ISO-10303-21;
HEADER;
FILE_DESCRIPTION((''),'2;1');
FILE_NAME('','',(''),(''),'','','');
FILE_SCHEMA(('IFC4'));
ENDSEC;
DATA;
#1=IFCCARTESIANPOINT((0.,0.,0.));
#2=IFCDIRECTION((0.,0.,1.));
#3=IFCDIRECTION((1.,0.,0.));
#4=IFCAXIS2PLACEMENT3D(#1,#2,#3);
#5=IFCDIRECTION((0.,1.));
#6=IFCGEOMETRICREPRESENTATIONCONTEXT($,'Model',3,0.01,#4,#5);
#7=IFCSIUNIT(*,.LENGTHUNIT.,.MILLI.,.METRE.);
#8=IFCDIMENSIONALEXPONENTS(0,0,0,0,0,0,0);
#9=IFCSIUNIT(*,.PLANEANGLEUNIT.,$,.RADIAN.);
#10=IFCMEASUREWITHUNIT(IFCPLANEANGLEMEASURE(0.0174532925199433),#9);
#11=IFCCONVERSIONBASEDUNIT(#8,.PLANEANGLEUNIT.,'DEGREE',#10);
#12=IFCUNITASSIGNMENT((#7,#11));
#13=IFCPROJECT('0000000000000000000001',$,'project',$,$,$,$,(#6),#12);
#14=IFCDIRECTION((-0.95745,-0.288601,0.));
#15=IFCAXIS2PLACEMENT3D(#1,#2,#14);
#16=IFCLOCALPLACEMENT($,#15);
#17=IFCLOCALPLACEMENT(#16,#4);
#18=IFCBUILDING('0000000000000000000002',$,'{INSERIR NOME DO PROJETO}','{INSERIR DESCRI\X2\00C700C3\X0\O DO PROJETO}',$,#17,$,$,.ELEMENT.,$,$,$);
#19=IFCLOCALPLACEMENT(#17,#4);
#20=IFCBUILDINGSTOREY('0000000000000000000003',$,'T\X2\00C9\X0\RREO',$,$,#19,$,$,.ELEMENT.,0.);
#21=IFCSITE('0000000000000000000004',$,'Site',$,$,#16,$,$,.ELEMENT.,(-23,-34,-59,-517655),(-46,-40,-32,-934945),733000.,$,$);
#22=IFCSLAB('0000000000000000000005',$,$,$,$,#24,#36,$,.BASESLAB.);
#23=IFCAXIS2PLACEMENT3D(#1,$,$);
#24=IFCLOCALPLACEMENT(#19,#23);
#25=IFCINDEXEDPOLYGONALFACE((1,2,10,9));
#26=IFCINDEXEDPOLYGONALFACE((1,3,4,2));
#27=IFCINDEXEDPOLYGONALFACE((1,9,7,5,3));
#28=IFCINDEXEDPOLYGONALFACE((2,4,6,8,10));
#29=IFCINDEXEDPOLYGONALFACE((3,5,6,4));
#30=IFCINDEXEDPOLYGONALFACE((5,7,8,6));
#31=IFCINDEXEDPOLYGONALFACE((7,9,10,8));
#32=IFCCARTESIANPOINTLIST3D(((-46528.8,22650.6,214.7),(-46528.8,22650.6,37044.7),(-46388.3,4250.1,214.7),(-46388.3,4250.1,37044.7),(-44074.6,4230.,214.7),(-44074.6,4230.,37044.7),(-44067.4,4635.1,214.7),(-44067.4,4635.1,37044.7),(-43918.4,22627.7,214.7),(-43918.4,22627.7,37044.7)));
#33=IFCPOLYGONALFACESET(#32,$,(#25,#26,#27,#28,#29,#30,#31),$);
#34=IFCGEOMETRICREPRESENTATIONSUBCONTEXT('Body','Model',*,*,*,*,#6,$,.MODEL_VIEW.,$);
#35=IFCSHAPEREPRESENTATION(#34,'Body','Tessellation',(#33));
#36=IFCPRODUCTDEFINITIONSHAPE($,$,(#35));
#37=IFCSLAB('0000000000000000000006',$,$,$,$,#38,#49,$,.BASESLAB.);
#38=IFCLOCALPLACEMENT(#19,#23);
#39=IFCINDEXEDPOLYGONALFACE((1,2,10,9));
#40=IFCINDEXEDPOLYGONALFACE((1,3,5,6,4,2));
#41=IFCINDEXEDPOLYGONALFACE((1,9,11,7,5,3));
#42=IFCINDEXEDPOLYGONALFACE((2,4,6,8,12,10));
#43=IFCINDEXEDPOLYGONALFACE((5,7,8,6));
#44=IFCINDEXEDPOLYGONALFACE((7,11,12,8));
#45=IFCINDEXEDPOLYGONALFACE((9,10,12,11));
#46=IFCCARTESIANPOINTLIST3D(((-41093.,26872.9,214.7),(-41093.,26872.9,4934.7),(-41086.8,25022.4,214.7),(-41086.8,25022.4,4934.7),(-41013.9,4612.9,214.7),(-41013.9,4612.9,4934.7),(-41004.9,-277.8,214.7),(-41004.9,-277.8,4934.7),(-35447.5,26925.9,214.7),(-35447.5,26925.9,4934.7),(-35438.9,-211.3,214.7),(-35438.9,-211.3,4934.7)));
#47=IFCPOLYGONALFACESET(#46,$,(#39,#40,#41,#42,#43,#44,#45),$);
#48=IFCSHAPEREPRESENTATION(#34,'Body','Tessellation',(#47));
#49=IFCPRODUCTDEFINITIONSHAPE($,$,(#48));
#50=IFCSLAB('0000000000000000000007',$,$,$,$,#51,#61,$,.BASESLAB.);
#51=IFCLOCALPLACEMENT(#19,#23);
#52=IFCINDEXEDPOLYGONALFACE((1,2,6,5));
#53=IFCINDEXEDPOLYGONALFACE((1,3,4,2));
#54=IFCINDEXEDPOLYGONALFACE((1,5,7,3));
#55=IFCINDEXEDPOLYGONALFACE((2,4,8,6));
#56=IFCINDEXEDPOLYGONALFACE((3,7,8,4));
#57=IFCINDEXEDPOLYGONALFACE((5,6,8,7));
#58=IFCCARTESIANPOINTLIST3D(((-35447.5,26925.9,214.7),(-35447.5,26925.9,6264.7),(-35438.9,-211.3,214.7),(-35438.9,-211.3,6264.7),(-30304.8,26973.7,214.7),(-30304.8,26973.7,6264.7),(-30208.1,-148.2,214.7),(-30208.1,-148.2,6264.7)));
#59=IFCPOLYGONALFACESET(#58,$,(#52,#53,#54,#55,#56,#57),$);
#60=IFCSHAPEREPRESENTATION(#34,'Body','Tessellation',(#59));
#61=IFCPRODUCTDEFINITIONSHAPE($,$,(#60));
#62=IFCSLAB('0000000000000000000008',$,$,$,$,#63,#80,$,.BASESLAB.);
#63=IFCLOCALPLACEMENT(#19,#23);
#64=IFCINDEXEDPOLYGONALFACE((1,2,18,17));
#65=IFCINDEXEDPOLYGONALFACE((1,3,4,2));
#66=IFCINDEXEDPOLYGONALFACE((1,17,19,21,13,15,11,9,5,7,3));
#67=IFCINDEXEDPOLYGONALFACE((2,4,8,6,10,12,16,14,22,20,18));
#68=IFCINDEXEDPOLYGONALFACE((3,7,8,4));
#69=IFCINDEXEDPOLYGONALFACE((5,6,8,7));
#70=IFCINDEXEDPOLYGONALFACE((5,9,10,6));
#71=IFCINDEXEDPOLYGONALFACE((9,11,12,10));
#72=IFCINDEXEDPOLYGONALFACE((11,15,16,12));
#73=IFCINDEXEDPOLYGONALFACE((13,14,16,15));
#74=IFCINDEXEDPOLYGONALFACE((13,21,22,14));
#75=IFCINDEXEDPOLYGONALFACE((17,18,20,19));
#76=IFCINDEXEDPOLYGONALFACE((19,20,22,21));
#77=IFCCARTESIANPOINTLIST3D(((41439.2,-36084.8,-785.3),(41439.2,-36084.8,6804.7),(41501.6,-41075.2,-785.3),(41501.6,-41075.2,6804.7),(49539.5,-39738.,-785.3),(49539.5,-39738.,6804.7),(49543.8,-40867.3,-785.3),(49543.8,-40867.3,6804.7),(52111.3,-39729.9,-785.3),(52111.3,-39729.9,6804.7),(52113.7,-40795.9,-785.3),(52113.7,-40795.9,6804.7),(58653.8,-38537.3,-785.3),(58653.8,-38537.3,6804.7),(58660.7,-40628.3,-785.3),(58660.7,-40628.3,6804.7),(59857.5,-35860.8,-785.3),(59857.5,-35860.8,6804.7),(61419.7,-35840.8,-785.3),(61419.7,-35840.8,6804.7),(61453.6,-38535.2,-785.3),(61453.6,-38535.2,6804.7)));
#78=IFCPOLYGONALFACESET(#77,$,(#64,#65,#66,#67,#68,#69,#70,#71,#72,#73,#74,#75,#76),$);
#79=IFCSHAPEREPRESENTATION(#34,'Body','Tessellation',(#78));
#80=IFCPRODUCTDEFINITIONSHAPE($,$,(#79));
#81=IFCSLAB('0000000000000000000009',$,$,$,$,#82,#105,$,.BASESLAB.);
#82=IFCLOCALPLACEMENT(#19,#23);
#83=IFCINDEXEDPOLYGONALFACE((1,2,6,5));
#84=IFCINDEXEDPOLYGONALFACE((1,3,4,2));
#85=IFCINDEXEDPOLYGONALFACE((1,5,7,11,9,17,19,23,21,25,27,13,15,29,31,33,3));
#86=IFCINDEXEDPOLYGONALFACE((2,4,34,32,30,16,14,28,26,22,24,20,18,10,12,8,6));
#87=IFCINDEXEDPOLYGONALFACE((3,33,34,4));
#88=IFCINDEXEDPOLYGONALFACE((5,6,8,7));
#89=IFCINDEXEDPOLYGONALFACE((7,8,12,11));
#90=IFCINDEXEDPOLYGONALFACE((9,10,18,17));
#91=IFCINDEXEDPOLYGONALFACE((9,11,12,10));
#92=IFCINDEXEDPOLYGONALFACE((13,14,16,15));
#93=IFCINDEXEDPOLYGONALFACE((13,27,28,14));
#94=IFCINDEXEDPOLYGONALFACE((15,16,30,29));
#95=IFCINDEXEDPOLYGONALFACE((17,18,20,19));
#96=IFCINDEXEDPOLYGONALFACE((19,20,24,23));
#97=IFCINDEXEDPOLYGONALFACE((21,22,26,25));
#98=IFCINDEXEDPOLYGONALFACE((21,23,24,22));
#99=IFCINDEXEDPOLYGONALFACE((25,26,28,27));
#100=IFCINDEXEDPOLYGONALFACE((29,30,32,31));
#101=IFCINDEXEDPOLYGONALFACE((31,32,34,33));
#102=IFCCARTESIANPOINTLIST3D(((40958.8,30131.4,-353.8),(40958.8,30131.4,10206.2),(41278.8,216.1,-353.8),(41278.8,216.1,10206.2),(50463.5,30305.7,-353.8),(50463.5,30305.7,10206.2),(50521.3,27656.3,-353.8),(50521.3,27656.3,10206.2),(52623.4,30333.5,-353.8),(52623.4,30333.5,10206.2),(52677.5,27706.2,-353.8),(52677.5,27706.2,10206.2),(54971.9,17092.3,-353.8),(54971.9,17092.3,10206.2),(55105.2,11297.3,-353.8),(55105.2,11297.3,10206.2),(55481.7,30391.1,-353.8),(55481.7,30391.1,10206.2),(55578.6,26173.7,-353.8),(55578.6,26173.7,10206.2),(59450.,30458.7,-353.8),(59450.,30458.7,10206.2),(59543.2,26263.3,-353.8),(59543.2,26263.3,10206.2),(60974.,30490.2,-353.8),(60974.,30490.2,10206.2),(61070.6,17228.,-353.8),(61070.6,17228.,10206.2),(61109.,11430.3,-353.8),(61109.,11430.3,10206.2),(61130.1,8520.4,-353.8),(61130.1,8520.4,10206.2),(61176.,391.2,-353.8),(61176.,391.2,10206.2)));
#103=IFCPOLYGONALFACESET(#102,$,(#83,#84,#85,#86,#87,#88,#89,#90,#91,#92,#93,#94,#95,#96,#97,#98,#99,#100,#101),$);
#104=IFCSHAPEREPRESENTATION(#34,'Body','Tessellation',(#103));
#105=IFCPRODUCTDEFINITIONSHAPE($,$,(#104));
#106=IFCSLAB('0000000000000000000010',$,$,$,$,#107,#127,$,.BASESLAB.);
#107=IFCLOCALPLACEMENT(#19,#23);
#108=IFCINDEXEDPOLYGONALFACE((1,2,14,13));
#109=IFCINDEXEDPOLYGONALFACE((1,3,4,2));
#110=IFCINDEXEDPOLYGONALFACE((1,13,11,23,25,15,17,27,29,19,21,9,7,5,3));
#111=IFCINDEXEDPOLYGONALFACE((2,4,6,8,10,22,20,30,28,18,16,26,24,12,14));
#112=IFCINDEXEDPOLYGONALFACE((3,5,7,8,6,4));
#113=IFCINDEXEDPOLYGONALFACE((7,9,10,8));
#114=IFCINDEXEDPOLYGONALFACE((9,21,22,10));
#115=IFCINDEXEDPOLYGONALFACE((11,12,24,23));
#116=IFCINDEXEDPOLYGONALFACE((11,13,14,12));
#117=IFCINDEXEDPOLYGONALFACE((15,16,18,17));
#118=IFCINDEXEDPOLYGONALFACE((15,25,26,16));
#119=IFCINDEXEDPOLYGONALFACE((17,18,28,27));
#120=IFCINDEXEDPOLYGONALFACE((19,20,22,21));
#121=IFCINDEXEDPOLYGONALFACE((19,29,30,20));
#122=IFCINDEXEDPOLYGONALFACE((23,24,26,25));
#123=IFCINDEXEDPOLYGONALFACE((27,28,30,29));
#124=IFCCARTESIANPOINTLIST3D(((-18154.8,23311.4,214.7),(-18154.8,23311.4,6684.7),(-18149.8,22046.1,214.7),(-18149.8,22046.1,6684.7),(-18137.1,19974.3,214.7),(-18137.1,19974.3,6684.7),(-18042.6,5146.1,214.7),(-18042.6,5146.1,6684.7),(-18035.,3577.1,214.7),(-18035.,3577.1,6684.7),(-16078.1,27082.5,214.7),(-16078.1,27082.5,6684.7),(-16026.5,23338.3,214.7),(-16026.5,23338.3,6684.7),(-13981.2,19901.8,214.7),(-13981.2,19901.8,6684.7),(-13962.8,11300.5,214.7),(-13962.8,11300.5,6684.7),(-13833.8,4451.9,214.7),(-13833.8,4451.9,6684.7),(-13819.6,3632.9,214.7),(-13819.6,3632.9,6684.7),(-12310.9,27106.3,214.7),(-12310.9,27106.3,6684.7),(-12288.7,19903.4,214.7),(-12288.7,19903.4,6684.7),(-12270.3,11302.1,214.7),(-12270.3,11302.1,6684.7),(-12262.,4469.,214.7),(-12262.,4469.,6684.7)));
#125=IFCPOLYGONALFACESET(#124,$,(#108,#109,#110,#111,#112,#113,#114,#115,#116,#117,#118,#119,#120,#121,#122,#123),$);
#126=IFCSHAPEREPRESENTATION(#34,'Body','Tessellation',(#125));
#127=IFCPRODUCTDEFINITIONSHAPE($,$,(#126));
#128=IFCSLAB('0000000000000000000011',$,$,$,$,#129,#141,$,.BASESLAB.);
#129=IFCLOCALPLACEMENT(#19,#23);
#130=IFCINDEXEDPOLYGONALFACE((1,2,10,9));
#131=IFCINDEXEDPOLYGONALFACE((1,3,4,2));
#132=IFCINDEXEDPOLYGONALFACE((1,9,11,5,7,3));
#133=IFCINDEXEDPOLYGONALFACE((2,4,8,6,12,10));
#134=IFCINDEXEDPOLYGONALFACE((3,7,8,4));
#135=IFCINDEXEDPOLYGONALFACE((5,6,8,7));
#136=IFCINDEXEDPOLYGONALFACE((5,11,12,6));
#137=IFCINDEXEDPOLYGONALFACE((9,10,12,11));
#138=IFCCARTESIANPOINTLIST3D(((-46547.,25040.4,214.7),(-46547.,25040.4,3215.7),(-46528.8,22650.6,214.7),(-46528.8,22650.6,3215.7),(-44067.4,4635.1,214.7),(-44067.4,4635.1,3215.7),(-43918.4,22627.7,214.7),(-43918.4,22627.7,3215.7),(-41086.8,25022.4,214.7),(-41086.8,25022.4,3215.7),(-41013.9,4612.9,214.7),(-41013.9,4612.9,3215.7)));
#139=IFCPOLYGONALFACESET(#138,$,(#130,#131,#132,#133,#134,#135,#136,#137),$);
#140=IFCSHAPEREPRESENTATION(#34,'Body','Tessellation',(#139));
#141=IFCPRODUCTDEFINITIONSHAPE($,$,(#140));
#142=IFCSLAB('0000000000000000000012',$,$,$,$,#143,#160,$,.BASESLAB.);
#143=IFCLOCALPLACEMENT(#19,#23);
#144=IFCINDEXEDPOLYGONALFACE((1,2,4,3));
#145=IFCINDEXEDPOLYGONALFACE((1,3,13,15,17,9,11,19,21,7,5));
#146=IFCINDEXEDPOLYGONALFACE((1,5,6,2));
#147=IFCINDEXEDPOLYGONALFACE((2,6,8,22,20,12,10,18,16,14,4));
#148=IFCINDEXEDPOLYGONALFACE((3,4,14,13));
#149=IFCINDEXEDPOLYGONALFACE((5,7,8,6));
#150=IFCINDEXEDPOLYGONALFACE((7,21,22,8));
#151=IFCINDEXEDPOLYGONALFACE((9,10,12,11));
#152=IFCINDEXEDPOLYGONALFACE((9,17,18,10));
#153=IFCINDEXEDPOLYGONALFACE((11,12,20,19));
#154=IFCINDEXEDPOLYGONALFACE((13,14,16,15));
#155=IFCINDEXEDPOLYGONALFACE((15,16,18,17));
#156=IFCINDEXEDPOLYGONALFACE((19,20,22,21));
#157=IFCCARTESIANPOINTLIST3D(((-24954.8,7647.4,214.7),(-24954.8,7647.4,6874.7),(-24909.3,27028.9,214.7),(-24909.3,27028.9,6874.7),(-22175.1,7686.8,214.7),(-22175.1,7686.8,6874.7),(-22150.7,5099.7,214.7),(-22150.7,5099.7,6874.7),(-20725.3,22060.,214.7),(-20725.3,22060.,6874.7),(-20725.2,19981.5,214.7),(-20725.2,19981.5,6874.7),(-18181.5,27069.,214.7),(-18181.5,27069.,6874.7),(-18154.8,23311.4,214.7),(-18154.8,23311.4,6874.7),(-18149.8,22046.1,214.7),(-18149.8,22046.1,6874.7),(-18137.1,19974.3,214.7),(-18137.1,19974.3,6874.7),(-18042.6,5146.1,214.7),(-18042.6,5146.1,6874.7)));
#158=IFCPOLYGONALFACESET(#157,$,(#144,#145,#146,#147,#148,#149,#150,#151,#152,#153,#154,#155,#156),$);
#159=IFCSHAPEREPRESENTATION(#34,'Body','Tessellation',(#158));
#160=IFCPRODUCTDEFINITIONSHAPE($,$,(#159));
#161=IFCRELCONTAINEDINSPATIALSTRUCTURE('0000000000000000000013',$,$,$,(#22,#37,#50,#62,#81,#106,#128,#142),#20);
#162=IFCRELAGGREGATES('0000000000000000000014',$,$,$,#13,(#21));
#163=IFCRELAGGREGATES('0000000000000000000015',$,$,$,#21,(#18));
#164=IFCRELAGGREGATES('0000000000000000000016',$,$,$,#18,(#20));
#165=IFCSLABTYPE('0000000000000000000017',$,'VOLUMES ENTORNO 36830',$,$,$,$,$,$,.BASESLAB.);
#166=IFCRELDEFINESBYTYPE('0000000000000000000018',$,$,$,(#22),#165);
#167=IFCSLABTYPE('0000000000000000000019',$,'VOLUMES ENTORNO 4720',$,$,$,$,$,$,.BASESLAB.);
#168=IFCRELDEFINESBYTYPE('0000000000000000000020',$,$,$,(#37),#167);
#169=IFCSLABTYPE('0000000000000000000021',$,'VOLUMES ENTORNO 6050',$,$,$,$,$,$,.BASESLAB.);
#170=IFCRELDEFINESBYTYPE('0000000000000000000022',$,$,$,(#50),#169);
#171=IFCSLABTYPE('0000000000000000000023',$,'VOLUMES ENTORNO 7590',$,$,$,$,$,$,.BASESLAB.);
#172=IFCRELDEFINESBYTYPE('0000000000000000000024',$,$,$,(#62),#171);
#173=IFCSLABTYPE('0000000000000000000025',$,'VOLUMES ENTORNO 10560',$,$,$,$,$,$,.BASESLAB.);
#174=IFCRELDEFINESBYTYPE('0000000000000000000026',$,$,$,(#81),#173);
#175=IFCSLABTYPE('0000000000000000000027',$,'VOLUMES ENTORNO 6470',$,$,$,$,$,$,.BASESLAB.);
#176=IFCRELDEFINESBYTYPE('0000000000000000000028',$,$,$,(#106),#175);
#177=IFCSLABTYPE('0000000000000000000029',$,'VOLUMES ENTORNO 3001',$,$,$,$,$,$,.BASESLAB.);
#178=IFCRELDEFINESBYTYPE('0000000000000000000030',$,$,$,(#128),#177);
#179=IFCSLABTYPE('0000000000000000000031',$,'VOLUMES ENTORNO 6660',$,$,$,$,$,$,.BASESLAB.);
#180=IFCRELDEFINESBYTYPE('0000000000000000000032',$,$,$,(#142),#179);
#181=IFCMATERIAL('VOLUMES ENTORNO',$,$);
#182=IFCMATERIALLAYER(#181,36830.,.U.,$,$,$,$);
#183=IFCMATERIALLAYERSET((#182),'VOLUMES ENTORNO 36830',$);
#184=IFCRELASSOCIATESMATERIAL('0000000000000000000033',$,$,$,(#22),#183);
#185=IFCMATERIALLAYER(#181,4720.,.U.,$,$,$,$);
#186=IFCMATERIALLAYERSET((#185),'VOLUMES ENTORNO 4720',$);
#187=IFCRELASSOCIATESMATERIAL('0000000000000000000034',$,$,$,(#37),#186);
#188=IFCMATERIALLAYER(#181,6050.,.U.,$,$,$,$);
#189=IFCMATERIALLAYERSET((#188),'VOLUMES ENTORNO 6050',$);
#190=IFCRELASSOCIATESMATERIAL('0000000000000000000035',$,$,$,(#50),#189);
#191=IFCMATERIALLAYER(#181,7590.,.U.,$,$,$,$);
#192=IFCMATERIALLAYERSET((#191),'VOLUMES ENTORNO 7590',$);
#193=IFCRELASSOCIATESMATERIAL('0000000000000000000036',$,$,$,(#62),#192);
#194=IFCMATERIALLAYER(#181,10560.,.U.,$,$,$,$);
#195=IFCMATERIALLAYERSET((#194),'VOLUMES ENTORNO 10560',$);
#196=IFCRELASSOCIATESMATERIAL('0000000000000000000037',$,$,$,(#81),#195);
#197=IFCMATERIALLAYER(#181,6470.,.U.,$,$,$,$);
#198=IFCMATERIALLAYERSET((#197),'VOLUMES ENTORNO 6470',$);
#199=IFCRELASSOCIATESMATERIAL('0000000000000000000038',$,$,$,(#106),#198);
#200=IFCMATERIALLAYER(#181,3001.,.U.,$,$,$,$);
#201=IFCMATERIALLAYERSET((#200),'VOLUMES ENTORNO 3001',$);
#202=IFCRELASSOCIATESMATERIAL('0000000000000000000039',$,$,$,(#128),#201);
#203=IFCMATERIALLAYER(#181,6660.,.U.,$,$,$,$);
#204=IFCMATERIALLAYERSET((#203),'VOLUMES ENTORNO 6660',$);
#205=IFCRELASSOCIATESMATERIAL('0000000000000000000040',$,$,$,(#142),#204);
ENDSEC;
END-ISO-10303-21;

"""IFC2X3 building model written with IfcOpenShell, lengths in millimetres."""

from ifc_helpers import new_model, entity, si_unit, converted_unit, direction, frame, origin_with_axes, place, context, subcontext, project, spatial, polyline, outline, extrude, material, layer, layer_set, layer_usage, type_object, element, save


model = new_model("IFC2X3")

# Units and contexts
model_context = context("Model", 3, precision=0.01, world=origin_with_axes(), true_north=direction((0.0, 1.0)))
body_context = subcontext(model_context, "Body", "Model", "MODEL_VIEW")
ifc_project = project(units=[si_unit("LENGTHUNIT", "METRE", prefix="MILLI"), converted_unit("PLANEANGLEUNIT", "DEGREE", entity("IfcPlaneAngleMeasure", 0.0174532925199433), si_unit("PLANEANGLEUNIT", "RADIAN"), dimensions=[0, 0, 0, 0, 0, 0, 0])], contexts=[model_context])

# Site, building, storey
site_placement = place(None, frame((0.0, 0.0, 0.0), z_axis=(0.0, 0.0, 1.0), x_axis=(-0.95745, -0.288601, 0.0)))
site = spatial("IfcSite", under=ifc_project, at=site_placement, Name="Site", CompositionType="ELEMENT", RefLatitude=(-23, -34, -59, -517655), RefLongitude=(-46, -40, -32, -934945), RefElevation=733000.0)
building_placement = place(site_placement, origin_with_axes())
building = spatial("IfcBuilding", under=site, at=building_placement, Name="{INSERIR NOME DO PROJETO}", Description="{INSERIR DESCRIÇÃO DO PROJETO}", CompositionType="ELEMENT")
storey_placement = place(building_placement, origin_with_axes())
storey = spatial("IfcBuildingStorey", under=building, at=storey_placement, Name="TÉRREO", CompositionType="ELEMENT", Elevation=0.0)

# Slabs
ifc_material_1 = material(Name="VOLUMES ENTORNO")
ifc_layer_1 = layer(ifc_material_1, 36830.0, ventilated="UNKNOWN")
ifc_layer_set_1 = layer_set([ifc_layer_1], Name="VOLUMES ENTORNO 36830")
ifc_layer_usage_1 = layer_usage(ifc_layer_set_1, "AXIS3", "NEGATIVE", 36830.0)
slab_type_1 = type_object("IfcSlabType", Name="VOLUMES ENTORNO 36830", PredefinedType="BASESLAB")
slab_1_placement = place(storey_placement, frame((-43918.4, 22627.7, 214.7), z_axis=(0.0, 0.0, 1.0), x_axis=(1.0, 0.0, 0.0)))
element("IfcSlab", 1, at=slab_1_placement, inside=storey, type_object=slab_type_1, material=ifc_layer_usage_1, PredefinedType="BASESLAB", context=body_context, shape_type="SweptSolid", body=[
    extrude(outline(polyline([(0.0, 0.0), (-2610.4, 22.9), (-2469.9, -18377.6), (-156.2, -18397.7), (-149.0, -17992.6), (0.0, 0.0)])), origin_with_axes(), (0.0, 0.0, 1.0), 36830.0),
])
ifc_layer_2 = layer(ifc_material_1, 4720.0, ventilated="UNKNOWN")
ifc_layer_set_2 = layer_set([ifc_layer_2], Name="VOLUMES ENTORNO 4720")
ifc_layer_usage_2 = layer_usage(ifc_layer_set_2, "AXIS3", "NEGATIVE", 4720.0)
slab_type_2 = type_object("IfcSlabType", Name="VOLUMES ENTORNO 4720", PredefinedType="BASESLAB")
slab_2_placement = place(storey_placement, frame((-41093.0, 26872.9, 214.7), z_axis=(0.0, 0.0, 1.0), x_axis=(1.0, 0.0, 0.0)))
element("IfcSlab", 2, at=slab_2_placement, inside=storey, type_object=slab_type_2, material=ifc_layer_usage_2, PredefinedType="BASESLAB", context=body_context, shape_type="SweptSolid", body=[
    extrude(outline(polyline([(0.0, 0.0), (6.2, -1850.5), (79.1, -22260.0), (88.0, -27150.7), (5654.1, -27084.2), (5645.5, 53.0), (0.0, 0.0)])), origin_with_axes(), (0.0, 0.0, 1.0), 4720.0),
])
ifc_layer_3 = layer(ifc_material_1, 6050.0, ventilated="UNKNOWN")
ifc_layer_set_3 = layer_set([ifc_layer_3], Name="VOLUMES ENTORNO 6050")
ifc_layer_usage_3 = layer_usage(ifc_layer_set_3, "AXIS3", "NEGATIVE", 6050.0)
slab_type_3 = type_object("IfcSlabType", Name="VOLUMES ENTORNO 6050", PredefinedType="BASESLAB")
slab_3_placement = place(storey_placement, frame((-35447.5, 26925.9, 214.7), z_axis=(0.0, 0.0, 1.0), x_axis=(1.0, 0.0, 0.0)))
element("IfcSlab", 3, at=slab_3_placement, inside=storey, type_object=slab_type_3, material=ifc_layer_usage_3, PredefinedType="BASESLAB", context=body_context, shape_type="SweptSolid", body=[
    extrude(outline(polyline([(0.0, 0.0), (8.6, -27137.2), (5239.3, -27074.1), (5142.6, 47.9), (0.0, 0.0)])), origin_with_axes(), (0.0, 0.0, 1.0), 6050.0),
])
ifc_layer_4 = layer(ifc_material_1, 7590.0, ventilated="UNKNOWN")
ifc_layer_set_4 = layer_set([ifc_layer_4], Name="VOLUMES ENTORNO 7590")
ifc_layer_usage_4 = layer_usage(ifc_layer_set_4, "AXIS3", "NEGATIVE", 7590.0)
slab_type_4 = type_object("IfcSlabType", Name="VOLUMES ENTORNO 7590", PredefinedType="BASESLAB")
slab_4_placement = place(storey_placement, frame((41501.6, -41075.2, -785.3), z_axis=(0.0, 0.0, 1.0), x_axis=(1.0, 0.0, 0.0)))
element("IfcSlab", 4, at=slab_4_placement, inside=storey, type_object=slab_type_4, material=ifc_layer_usage_4, PredefinedType="BASESLAB", context=body_context, shape_type="SweptSolid", body=[
    extrude(outline(polyline([(0.0, 0.0), (8042.2, 207.9), (8037.9, 1337.1), (10609.7, 1345.3), (10612.1, 279.2), (17159.1, 446.9), (17152.3, 2537.8), (19952.0, 2539.9), (19918.2, 5234.3), (18355.9, 5214.3), (-62.4, 4990.4), (0.0, 0.0)])), origin_with_axes(), (0.0, 0.0, 1.0), 7590.0),
])
ifc_layer_5 = layer(ifc_material_1, 10560.0, ventilated="UNKNOWN")
ifc_layer_set_5 = layer_set([ifc_layer_5], Name="VOLUMES ENTORNO 10560")
ifc_layer_usage_5 = layer_usage(ifc_layer_set_5, "AXIS3", "NEGATIVE", 10560.0)
slab_type_5 = type_object("IfcSlabType", Name="VOLUMES ENTORNO 10560", PredefinedType="BASESLAB")
slab_5_placement = place(storey_placement, frame((61176.0, 391.2, -353.8), z_axis=(0.0, 0.0, 1.0), x_axis=(1.0, 0.0, 0.0)))
element("IfcSlab", 5, at=slab_5_placement, inside=storey, type_object=slab_type_5, material=ifc_layer_usage_5, PredefinedType="BASESLAB", context=body_context, shape_type="SweptSolid", body=[
    extrude(outline(polyline([(0.0, 0.0), (-45.9, 8129.1), (-67.0, 11039.0), (-6070.8, 10906.1), (-6204.0, 16701.1), (-105.4, 16836.8), (-202.0, 30099.0), (-1725.9, 30067.5), (-1632.8, 25872.1), (-5597.3, 25782.5), (-5694.3, 29999.9), (-8552.5, 29942.3), (-8498.5, 27314.9), (-10654.6, 27265.1), (-10712.5, 29914.5), (-20217.2, 29740.2), (-19897.2, -175.1), (0.0, 0.0)])), origin_with_axes(), (0.0, 0.0, 1.0), 10560.0),
])
ifc_layer_6 = layer(ifc_material_1, 6470.0, ventilated="UNKNOWN")
ifc_layer_set_6 = layer_set([ifc_layer_6], Name="VOLUMES ENTORNO 6470")
ifc_layer_usage_6 = layer_usage(ifc_layer_set_6, "AXIS3", "NEGATIVE", 6470.0)
slab_type_6 = type_object("IfcSlabType", Name="VOLUMES ENTORNO 6470", PredefinedType="BASESLAB")
slab_6_placement = place(storey_placement, frame((-13819.6, 3632.9, 214.7), z_axis=(0.0, 0.0, 1.0), x_axis=(1.0, 0.0, 0.0)))
element("IfcSlab", 6, at=slab_6_placement, inside=storey, type_object=slab_type_6, material=ifc_layer_usage_6, PredefinedType="BASESLAB", context=body_context, shape_type="SweptSolid", body=[
    extrude(outline(polyline([(0.0, 0.0), (-14.3, 819.0), (1557.6, 836.1), (1549.3, 7669.2), (-143.2, 7667.6), (-161.7, 16268.9), (1530.8, 16270.5), (1508.6, 23473.4), (-2258.5, 23449.6), (-2206.9, 19705.4), (-4335.2, 19678.5), (-4330.2, 18413.2), (-4317.6, 16341.4), (-4223.0, 1513.1), (-4215.5, -55.8), (0.0, 0.0)])), origin_with_axes(), (0.0, 0.0, 1.0), 6470.0),
])
ifc_layer_7 = layer(ifc_material_1, 3001.0, ventilated="UNKNOWN")
ifc_layer_set_7 = layer_set([ifc_layer_7], Name="VOLUMES ENTORNO 3001")
ifc_layer_usage_7 = layer_usage(ifc_layer_set_7, "AXIS3", "NEGATIVE", 3001.0)
slab_type_7 = type_object("IfcSlabType", Name="VOLUMES ENTORNO 3001", PredefinedType="BASESLAB")
slab_7_placement = place(storey_placement, frame((-43918.4, 22627.7, 214.7), z_axis=(0.0, 0.0, 1.0), x_axis=(1.0, 0.0, 0.0)))
element("IfcSlab", 7, at=slab_7_placement, inside=storey, type_object=slab_type_7, material=ifc_layer_usage_7, PredefinedType="BASESLAB", context=body_context, shape_type="SweptSolid", body=[
    extrude(outline(polyline([(0.0, 0.0), (-149.0, -17992.6), (2904.5, -18014.8), (2831.6, 2394.7), (-2628.6, 2412.7), (-2610.4, 22.9), (0.0, 0.0)])), origin_with_axes(), (0.0, 0.0, 1.0), 3001.0),
])
ifc_layer_8 = layer(ifc_material_1, 6660.0, ventilated="UNKNOWN")
ifc_layer_set_8 = layer_set([ifc_layer_8], Name="VOLUMES ENTORNO 6660")
ifc_layer_usage_8 = layer_usage(ifc_layer_set_8, "AXIS3", "NEGATIVE", 6660.0)
slab_type_8 = type_object("IfcSlabType", Name="VOLUMES ENTORNO 6660", PredefinedType="BASESLAB")
slab_8_placement = place(storey_placement, frame((-22150.7, 5099.7, 214.7), z_axis=(0.0, 0.0, 1.0), x_axis=(1.0, 0.0, 0.0)))
element("IfcSlab", 8, at=slab_8_placement, inside=storey, type_object=slab_type_8, material=ifc_layer_usage_8, PredefinedType="BASESLAB", context=body_context, shape_type="SweptSolid", body=[
    extrude(outline(polyline([(0.0, 0.0), (4108.2, 46.3), (4013.6, 14874.6), (1425.6, 14881.8), (1425.4, 16960.3), (4001.0, 16946.4), (3995.9, 18211.7), (3969.2, 21969.3), (-2758.6, 21929.2), (-2804.1, 2547.7), (-24.4, 2587.1), (0.0, 0.0)])), origin_with_axes(), (0.0, 0.0, 1.0), 6660.0),
])

save(model, "model.ifc")
